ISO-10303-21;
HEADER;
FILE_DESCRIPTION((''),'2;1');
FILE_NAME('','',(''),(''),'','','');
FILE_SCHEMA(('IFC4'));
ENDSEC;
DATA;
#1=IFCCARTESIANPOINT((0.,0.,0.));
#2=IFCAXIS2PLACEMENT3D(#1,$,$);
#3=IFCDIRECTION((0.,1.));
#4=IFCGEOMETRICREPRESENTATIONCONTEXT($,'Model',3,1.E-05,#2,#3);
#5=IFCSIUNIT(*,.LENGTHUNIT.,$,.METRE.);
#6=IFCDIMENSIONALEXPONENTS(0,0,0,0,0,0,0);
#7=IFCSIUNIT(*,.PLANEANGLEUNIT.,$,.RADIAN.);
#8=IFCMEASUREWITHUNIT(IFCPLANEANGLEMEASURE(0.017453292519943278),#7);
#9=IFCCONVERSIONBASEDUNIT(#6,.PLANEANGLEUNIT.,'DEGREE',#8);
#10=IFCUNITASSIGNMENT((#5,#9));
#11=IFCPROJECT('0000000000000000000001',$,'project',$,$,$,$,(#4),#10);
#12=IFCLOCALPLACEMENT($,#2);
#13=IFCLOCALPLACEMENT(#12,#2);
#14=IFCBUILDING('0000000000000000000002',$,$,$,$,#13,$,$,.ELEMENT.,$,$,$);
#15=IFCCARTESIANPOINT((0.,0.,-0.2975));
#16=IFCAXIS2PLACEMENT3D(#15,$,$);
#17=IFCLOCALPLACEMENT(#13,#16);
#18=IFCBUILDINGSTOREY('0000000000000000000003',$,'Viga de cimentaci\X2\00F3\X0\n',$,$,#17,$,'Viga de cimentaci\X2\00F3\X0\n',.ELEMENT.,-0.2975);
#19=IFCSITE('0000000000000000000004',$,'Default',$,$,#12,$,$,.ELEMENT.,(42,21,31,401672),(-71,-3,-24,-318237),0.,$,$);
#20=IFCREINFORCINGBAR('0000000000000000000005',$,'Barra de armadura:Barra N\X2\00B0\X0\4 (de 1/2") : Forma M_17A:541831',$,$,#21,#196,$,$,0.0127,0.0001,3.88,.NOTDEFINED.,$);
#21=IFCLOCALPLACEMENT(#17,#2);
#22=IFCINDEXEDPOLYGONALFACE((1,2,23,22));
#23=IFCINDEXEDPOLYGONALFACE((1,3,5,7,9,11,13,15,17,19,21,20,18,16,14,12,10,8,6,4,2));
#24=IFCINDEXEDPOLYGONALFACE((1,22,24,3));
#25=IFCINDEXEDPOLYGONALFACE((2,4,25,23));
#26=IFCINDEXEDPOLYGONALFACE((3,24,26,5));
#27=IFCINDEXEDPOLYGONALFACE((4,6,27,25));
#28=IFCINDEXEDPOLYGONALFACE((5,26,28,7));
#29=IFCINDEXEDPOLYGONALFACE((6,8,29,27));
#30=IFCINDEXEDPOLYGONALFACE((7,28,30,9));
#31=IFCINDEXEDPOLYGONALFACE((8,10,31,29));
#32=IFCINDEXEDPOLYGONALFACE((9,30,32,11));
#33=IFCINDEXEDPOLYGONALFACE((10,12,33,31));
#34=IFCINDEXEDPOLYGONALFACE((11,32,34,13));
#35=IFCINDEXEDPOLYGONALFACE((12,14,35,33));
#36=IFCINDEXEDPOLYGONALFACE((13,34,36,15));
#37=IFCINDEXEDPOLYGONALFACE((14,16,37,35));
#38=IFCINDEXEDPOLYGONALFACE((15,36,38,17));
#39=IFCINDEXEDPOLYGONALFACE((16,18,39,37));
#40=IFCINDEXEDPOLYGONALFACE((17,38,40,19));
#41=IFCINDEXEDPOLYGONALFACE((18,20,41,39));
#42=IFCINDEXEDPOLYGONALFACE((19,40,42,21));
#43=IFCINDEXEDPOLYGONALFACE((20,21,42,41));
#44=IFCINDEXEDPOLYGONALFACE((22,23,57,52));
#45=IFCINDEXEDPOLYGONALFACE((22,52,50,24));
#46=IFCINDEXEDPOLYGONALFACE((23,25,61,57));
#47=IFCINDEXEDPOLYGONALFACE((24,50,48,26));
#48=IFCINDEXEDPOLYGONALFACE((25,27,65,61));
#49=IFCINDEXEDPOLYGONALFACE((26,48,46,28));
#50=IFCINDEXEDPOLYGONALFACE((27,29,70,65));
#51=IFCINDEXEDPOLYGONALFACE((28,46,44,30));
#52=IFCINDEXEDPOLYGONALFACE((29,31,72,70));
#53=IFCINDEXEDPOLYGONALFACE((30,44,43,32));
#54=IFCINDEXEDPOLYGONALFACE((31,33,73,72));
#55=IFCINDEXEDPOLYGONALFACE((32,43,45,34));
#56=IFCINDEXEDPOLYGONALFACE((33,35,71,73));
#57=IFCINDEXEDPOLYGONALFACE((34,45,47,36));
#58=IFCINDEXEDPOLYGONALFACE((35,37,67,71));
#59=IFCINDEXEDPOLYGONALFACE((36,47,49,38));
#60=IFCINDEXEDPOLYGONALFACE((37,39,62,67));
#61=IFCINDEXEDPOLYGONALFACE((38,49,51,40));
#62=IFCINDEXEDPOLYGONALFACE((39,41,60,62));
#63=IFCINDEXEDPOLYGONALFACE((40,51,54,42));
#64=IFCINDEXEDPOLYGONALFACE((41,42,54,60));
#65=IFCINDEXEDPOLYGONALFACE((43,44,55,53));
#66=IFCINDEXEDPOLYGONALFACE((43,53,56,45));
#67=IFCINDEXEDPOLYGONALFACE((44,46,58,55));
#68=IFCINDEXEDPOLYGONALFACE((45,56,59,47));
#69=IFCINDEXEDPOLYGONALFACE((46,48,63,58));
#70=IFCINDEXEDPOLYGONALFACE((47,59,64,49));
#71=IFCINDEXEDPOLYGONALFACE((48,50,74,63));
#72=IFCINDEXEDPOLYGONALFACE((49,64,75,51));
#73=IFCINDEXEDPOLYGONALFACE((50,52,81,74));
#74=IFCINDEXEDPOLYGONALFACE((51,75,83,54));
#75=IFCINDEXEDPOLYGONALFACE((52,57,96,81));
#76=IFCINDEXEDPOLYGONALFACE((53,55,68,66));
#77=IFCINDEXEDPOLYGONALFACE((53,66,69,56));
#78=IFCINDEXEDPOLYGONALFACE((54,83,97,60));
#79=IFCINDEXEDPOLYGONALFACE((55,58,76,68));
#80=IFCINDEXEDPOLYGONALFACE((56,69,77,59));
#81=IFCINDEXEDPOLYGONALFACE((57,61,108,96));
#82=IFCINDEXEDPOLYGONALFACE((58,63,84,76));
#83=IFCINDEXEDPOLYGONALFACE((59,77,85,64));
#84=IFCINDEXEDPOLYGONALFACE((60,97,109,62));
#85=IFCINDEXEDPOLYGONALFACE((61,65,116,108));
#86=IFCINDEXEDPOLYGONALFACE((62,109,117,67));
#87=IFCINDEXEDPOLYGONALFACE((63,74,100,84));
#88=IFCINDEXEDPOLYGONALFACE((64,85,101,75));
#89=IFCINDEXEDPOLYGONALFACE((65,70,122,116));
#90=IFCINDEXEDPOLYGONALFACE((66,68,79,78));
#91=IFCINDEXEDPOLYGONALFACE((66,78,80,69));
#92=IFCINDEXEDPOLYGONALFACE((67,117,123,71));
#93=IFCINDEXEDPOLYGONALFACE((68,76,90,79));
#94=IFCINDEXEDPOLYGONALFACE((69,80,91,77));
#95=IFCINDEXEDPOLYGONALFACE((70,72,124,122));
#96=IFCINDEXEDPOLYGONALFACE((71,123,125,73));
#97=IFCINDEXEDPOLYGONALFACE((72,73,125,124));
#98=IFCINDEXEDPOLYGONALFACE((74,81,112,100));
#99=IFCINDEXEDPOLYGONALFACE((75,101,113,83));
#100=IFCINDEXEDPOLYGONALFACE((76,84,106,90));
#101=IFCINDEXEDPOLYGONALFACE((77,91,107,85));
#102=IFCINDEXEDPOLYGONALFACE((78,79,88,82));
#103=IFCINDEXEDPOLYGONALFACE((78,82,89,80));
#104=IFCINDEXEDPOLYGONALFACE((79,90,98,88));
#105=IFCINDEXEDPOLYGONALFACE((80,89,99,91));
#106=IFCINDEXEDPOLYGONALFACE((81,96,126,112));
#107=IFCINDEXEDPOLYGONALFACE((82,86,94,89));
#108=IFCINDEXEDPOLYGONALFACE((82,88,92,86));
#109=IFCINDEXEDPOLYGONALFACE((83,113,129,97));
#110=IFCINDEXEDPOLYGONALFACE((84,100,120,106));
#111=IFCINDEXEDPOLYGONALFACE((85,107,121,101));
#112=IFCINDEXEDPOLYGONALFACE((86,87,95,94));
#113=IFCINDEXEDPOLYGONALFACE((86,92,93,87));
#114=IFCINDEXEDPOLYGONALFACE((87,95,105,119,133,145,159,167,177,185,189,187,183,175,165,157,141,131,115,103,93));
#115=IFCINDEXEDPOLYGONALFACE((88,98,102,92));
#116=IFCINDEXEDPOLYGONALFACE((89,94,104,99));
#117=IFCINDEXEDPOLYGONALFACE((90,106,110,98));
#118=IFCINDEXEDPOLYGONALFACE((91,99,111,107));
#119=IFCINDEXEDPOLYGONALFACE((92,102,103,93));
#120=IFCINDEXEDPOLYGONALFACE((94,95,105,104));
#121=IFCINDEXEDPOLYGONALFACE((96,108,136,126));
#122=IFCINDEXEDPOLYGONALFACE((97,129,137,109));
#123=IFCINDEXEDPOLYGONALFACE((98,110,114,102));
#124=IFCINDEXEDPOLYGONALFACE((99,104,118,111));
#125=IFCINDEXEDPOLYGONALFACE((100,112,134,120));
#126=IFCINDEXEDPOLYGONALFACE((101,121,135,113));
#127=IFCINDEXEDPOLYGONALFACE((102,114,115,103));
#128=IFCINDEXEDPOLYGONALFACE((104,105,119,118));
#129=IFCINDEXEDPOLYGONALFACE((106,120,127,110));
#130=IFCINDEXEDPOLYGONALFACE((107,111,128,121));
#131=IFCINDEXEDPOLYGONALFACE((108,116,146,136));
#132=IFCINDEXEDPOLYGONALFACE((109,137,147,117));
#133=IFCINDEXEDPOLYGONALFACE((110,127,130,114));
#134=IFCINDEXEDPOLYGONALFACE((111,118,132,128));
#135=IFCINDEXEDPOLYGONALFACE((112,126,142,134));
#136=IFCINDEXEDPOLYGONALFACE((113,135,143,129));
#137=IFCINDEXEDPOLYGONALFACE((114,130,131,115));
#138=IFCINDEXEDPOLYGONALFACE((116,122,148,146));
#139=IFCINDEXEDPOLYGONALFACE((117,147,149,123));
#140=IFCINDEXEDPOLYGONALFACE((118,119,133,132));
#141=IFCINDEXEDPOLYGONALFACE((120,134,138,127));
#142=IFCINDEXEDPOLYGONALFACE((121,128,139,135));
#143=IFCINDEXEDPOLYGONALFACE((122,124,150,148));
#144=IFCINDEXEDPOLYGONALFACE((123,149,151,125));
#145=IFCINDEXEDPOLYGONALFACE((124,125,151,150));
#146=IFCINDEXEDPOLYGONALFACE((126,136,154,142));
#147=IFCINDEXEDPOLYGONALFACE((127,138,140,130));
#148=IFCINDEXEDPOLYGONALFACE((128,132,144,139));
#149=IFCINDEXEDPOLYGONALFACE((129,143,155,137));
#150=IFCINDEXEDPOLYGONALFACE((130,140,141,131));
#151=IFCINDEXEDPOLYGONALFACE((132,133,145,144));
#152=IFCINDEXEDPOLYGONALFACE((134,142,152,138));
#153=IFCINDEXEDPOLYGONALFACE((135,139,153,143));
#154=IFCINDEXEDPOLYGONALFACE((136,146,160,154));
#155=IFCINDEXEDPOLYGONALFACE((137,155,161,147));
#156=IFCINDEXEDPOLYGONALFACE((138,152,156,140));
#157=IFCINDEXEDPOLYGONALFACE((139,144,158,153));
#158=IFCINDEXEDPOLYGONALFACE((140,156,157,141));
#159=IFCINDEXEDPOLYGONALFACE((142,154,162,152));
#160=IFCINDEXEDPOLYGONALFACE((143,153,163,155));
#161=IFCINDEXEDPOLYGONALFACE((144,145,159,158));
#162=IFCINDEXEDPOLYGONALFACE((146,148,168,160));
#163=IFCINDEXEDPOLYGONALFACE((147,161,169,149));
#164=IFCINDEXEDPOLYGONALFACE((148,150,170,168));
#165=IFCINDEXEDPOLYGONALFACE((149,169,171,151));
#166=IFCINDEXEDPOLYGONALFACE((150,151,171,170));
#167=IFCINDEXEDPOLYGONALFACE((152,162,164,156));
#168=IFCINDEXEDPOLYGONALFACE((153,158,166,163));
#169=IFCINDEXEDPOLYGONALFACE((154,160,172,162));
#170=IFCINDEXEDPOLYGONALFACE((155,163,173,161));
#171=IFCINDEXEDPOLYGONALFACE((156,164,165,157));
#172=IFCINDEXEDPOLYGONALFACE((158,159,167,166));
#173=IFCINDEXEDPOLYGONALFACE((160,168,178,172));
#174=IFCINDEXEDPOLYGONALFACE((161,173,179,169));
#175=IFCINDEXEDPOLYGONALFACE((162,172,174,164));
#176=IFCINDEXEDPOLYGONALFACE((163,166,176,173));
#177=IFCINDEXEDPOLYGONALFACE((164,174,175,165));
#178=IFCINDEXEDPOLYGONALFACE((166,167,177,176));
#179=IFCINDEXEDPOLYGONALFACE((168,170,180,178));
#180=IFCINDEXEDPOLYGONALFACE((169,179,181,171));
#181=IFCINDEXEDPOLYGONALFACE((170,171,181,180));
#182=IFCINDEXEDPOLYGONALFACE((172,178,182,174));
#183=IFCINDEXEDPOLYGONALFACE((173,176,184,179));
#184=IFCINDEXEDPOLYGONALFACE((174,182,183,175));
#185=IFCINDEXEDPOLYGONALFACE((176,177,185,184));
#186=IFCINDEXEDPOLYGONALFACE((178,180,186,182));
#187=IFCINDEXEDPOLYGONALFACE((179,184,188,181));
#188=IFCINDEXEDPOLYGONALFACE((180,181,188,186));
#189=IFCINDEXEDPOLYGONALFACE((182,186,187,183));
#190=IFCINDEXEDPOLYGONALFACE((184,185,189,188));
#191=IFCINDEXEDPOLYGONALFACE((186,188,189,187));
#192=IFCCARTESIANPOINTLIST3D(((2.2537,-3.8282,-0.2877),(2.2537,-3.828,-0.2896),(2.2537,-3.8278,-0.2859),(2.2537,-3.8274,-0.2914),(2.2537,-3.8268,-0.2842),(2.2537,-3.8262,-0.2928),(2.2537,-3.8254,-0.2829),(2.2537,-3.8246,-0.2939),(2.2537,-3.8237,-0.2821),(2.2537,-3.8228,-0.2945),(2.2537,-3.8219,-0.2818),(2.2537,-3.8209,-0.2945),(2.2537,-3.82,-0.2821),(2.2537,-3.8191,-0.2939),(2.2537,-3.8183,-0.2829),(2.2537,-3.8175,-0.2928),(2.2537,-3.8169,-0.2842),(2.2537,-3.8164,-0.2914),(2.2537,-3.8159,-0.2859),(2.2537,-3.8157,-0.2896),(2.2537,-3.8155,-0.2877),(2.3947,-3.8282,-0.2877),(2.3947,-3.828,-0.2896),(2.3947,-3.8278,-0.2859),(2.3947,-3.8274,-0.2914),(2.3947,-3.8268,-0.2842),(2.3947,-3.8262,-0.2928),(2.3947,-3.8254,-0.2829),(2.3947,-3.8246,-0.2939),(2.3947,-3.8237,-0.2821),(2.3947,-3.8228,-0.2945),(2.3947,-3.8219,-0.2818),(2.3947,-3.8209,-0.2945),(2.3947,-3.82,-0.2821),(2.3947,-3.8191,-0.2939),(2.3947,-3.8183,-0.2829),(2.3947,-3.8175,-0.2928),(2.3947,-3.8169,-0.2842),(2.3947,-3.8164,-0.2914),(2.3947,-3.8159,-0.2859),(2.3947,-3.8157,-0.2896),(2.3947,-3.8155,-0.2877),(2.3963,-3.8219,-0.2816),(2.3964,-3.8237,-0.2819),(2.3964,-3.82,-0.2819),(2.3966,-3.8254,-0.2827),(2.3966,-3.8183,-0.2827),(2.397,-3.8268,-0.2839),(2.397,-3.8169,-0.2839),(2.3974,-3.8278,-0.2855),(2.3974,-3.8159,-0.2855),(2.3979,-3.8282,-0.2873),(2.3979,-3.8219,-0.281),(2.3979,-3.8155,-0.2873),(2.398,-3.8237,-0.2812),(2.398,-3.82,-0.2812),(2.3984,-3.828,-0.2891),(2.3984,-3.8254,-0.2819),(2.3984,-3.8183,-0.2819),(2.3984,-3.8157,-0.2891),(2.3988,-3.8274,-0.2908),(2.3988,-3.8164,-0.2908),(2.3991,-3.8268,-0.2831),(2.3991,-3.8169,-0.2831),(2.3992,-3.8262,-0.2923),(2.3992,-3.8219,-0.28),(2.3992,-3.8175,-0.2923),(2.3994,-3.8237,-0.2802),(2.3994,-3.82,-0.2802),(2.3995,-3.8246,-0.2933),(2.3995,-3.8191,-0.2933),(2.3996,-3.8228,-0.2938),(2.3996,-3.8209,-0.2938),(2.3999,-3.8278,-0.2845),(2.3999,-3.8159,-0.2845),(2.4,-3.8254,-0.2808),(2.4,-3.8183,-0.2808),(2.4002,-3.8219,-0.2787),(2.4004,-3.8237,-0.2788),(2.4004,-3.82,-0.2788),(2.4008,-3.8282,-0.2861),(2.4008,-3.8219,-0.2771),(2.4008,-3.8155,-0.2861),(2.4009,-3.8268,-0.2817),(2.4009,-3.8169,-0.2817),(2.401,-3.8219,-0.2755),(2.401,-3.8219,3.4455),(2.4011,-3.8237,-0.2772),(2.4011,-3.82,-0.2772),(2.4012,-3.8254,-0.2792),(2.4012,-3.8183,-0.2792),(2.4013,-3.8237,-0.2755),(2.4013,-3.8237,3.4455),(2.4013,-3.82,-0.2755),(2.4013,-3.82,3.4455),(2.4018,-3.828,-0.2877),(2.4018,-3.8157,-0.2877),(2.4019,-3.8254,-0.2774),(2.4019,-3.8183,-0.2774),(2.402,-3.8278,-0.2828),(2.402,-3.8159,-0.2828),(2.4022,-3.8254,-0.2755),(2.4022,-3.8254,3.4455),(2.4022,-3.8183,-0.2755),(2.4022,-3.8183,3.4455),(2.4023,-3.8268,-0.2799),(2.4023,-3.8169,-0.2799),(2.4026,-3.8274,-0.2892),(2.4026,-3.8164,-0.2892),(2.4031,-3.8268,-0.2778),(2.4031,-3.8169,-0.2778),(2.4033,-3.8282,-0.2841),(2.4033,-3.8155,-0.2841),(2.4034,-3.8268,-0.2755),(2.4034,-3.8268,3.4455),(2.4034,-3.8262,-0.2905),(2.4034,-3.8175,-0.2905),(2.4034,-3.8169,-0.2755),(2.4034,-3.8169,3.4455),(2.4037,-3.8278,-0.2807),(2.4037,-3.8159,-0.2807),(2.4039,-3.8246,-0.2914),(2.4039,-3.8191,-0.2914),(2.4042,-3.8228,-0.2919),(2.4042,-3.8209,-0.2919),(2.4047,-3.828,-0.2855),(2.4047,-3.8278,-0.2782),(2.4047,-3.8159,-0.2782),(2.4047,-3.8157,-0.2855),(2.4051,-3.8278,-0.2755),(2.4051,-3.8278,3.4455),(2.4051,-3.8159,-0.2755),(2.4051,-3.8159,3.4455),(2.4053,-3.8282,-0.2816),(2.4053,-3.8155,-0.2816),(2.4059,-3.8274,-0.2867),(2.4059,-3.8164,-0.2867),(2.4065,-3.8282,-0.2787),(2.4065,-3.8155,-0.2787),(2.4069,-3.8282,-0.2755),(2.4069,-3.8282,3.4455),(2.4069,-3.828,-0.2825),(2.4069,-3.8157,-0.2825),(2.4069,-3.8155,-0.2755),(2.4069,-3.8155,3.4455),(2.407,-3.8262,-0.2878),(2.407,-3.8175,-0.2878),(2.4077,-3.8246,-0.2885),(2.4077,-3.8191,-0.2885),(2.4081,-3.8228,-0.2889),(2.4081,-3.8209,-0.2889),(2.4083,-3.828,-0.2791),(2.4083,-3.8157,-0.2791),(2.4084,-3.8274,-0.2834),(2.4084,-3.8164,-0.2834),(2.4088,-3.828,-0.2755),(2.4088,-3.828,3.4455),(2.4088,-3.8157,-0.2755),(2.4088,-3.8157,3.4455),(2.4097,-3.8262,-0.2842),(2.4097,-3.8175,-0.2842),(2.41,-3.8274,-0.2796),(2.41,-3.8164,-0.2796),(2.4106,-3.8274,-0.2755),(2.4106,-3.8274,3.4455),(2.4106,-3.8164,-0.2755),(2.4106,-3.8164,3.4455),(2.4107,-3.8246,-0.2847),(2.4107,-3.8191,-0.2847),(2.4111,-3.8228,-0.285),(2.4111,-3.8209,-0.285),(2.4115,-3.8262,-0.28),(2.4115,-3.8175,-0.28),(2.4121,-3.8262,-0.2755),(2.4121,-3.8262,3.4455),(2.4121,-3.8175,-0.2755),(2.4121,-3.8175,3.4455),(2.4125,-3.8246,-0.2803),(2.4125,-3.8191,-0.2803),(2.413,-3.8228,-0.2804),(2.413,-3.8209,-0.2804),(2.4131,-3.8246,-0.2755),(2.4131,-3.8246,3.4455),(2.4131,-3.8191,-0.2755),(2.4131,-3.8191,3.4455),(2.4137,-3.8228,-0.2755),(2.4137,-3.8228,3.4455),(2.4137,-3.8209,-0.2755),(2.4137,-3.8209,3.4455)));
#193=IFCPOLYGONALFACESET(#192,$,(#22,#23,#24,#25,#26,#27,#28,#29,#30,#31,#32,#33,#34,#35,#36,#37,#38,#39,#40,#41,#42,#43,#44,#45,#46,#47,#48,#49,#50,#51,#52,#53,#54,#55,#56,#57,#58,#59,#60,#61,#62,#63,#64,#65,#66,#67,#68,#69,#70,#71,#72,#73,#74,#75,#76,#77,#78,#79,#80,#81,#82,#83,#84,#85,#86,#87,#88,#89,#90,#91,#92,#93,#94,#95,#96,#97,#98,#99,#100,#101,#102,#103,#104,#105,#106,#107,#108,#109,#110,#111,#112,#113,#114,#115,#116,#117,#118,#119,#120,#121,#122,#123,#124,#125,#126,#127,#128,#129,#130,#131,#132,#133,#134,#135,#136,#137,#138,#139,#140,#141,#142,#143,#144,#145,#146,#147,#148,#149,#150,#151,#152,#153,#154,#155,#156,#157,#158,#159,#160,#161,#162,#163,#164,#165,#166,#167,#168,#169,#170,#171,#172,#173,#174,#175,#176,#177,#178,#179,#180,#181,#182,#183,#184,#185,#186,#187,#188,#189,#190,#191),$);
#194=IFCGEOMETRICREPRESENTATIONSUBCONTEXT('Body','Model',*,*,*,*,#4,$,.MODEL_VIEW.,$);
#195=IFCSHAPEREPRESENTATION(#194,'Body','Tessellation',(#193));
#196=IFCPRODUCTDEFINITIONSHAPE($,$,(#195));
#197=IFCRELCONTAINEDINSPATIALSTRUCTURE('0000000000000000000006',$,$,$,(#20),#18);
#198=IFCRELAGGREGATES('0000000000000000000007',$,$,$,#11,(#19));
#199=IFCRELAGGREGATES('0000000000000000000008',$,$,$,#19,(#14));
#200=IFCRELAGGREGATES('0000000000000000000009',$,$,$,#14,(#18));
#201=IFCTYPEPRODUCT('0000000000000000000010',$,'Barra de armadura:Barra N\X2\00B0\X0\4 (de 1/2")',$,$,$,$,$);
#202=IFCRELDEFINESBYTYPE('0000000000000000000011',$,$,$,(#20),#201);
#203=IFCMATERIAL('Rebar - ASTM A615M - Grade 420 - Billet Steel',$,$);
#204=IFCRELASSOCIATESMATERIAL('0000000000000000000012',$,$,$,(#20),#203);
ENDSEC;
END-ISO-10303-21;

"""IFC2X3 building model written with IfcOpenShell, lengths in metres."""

from ifc_helpers import new_model, entity, si_unit, converted_unit, direction, frame, origin, place, context, subcontext, project, spatial, material, type_object, element, save


model = new_model("IFC2X3")

# Units and contexts
model_context = context("Model", 3, precision=1e-05, world=origin(), true_north=direction((0.0, 1.0)))
body_context = subcontext(model_context, "Body", "Model", "MODEL_VIEW")
ifc_project = project(units=[si_unit("LENGTHUNIT", "METRE"), converted_unit("PLANEANGLEUNIT", "DEGREE", entity("IfcPlaneAngleMeasure", 0.017453292519943278), si_unit("PLANEANGLEUNIT", "RADIAN"), dimensions=[0, 0, 0, 0, 0, 0, 0])], contexts=[model_context])

# Site, building, storey
site_placement = place(None, origin())
site = spatial("IfcSite", under=ifc_project, at=site_placement, Name="Default", CompositionType="ELEMENT", RefLatitude=(42, 21, 31, 401672), RefLongitude=(-71, -3, -24, -318237), RefElevation=0.0)
building_placement = place(site_placement, origin())
building = spatial("IfcBuilding", under=site, at=building_placement, CompositionType="ELEMENT")
storey_placement = place(building_placement, frame((0.0, 0.0, -0.2975)))
storey = spatial("IfcBuildingStorey", under=building, at=storey_placement, Name="Viga de cimentación", LongName="Viga de cimentación", CompositionType="ELEMENT", Elevation=-0.2975)

# Reinforcing bar
ifc_material_1 = material(Name="Rebar - ASTM A615M - Grade 420 - Billet Steel")
type_product_1 = type_object("IfcTypeProduct", Name="Barra de armadura:Barra N°4 (de 1/2\")")
reinforcing_bar_1_placement = place(storey_placement, origin())
element("IfcReinforcingBar", 1, at=reinforcing_bar_1_placement, inside=storey, type_object=type_product_1, material=ifc_material_1, Name="Barra de armadura:Barra N°4 (de 1/2\") : Forma M_17A:541831", BarLength=3.88, BarRole="NOTDEFINED", CrossSectionArea=0.0001, NominalDiameter=0.0127, context=body_context, shape_type="AdvancedSweptSolid", body=[
    entity("IfcSweptDiskSolid", entity("IfcCompositeCurve", [entity("IfcCompositeCurveSegment", "CONTINUOUS", True, entity("IfcPolyline", [entity("IfcCartesianPoint", [2.4074, -3.8219, 3.4455]), entity("IfcCartesianPoint", [2.4074, -3.8219, -0.2755])])), entity("IfcCompositeCurveSegment", "CONTINUOUS", True, entity("IfcTrimmedCurve", entity("IfcCircle", entity("IfcAxis2Placement3D", entity("IfcCartesianPoint", [2.3947, -3.8219, -0.2755]), entity("IfcDirection", [0.0, 1.0, 0.0]), entity("IfcDirection", [0.0, 0.0, -1.0])), 0.0127), [entity("IfcParameterValue", 270.0)], [entity("IfcParameterValue", 360.0)], True, "PARAMETER")), entity("IfcCompositeCurveSegment", "CONTINUOUS", True, entity("IfcPolyline", [entity("IfcCartesianPoint", [2.3947, -3.8219, -0.2882]), entity("IfcCartesianPoint", [2.2537, -3.8219, -0.2882])]))], False), 0.0063, None, 0.0, 92.0),
])

save(model, "model.ifc")
